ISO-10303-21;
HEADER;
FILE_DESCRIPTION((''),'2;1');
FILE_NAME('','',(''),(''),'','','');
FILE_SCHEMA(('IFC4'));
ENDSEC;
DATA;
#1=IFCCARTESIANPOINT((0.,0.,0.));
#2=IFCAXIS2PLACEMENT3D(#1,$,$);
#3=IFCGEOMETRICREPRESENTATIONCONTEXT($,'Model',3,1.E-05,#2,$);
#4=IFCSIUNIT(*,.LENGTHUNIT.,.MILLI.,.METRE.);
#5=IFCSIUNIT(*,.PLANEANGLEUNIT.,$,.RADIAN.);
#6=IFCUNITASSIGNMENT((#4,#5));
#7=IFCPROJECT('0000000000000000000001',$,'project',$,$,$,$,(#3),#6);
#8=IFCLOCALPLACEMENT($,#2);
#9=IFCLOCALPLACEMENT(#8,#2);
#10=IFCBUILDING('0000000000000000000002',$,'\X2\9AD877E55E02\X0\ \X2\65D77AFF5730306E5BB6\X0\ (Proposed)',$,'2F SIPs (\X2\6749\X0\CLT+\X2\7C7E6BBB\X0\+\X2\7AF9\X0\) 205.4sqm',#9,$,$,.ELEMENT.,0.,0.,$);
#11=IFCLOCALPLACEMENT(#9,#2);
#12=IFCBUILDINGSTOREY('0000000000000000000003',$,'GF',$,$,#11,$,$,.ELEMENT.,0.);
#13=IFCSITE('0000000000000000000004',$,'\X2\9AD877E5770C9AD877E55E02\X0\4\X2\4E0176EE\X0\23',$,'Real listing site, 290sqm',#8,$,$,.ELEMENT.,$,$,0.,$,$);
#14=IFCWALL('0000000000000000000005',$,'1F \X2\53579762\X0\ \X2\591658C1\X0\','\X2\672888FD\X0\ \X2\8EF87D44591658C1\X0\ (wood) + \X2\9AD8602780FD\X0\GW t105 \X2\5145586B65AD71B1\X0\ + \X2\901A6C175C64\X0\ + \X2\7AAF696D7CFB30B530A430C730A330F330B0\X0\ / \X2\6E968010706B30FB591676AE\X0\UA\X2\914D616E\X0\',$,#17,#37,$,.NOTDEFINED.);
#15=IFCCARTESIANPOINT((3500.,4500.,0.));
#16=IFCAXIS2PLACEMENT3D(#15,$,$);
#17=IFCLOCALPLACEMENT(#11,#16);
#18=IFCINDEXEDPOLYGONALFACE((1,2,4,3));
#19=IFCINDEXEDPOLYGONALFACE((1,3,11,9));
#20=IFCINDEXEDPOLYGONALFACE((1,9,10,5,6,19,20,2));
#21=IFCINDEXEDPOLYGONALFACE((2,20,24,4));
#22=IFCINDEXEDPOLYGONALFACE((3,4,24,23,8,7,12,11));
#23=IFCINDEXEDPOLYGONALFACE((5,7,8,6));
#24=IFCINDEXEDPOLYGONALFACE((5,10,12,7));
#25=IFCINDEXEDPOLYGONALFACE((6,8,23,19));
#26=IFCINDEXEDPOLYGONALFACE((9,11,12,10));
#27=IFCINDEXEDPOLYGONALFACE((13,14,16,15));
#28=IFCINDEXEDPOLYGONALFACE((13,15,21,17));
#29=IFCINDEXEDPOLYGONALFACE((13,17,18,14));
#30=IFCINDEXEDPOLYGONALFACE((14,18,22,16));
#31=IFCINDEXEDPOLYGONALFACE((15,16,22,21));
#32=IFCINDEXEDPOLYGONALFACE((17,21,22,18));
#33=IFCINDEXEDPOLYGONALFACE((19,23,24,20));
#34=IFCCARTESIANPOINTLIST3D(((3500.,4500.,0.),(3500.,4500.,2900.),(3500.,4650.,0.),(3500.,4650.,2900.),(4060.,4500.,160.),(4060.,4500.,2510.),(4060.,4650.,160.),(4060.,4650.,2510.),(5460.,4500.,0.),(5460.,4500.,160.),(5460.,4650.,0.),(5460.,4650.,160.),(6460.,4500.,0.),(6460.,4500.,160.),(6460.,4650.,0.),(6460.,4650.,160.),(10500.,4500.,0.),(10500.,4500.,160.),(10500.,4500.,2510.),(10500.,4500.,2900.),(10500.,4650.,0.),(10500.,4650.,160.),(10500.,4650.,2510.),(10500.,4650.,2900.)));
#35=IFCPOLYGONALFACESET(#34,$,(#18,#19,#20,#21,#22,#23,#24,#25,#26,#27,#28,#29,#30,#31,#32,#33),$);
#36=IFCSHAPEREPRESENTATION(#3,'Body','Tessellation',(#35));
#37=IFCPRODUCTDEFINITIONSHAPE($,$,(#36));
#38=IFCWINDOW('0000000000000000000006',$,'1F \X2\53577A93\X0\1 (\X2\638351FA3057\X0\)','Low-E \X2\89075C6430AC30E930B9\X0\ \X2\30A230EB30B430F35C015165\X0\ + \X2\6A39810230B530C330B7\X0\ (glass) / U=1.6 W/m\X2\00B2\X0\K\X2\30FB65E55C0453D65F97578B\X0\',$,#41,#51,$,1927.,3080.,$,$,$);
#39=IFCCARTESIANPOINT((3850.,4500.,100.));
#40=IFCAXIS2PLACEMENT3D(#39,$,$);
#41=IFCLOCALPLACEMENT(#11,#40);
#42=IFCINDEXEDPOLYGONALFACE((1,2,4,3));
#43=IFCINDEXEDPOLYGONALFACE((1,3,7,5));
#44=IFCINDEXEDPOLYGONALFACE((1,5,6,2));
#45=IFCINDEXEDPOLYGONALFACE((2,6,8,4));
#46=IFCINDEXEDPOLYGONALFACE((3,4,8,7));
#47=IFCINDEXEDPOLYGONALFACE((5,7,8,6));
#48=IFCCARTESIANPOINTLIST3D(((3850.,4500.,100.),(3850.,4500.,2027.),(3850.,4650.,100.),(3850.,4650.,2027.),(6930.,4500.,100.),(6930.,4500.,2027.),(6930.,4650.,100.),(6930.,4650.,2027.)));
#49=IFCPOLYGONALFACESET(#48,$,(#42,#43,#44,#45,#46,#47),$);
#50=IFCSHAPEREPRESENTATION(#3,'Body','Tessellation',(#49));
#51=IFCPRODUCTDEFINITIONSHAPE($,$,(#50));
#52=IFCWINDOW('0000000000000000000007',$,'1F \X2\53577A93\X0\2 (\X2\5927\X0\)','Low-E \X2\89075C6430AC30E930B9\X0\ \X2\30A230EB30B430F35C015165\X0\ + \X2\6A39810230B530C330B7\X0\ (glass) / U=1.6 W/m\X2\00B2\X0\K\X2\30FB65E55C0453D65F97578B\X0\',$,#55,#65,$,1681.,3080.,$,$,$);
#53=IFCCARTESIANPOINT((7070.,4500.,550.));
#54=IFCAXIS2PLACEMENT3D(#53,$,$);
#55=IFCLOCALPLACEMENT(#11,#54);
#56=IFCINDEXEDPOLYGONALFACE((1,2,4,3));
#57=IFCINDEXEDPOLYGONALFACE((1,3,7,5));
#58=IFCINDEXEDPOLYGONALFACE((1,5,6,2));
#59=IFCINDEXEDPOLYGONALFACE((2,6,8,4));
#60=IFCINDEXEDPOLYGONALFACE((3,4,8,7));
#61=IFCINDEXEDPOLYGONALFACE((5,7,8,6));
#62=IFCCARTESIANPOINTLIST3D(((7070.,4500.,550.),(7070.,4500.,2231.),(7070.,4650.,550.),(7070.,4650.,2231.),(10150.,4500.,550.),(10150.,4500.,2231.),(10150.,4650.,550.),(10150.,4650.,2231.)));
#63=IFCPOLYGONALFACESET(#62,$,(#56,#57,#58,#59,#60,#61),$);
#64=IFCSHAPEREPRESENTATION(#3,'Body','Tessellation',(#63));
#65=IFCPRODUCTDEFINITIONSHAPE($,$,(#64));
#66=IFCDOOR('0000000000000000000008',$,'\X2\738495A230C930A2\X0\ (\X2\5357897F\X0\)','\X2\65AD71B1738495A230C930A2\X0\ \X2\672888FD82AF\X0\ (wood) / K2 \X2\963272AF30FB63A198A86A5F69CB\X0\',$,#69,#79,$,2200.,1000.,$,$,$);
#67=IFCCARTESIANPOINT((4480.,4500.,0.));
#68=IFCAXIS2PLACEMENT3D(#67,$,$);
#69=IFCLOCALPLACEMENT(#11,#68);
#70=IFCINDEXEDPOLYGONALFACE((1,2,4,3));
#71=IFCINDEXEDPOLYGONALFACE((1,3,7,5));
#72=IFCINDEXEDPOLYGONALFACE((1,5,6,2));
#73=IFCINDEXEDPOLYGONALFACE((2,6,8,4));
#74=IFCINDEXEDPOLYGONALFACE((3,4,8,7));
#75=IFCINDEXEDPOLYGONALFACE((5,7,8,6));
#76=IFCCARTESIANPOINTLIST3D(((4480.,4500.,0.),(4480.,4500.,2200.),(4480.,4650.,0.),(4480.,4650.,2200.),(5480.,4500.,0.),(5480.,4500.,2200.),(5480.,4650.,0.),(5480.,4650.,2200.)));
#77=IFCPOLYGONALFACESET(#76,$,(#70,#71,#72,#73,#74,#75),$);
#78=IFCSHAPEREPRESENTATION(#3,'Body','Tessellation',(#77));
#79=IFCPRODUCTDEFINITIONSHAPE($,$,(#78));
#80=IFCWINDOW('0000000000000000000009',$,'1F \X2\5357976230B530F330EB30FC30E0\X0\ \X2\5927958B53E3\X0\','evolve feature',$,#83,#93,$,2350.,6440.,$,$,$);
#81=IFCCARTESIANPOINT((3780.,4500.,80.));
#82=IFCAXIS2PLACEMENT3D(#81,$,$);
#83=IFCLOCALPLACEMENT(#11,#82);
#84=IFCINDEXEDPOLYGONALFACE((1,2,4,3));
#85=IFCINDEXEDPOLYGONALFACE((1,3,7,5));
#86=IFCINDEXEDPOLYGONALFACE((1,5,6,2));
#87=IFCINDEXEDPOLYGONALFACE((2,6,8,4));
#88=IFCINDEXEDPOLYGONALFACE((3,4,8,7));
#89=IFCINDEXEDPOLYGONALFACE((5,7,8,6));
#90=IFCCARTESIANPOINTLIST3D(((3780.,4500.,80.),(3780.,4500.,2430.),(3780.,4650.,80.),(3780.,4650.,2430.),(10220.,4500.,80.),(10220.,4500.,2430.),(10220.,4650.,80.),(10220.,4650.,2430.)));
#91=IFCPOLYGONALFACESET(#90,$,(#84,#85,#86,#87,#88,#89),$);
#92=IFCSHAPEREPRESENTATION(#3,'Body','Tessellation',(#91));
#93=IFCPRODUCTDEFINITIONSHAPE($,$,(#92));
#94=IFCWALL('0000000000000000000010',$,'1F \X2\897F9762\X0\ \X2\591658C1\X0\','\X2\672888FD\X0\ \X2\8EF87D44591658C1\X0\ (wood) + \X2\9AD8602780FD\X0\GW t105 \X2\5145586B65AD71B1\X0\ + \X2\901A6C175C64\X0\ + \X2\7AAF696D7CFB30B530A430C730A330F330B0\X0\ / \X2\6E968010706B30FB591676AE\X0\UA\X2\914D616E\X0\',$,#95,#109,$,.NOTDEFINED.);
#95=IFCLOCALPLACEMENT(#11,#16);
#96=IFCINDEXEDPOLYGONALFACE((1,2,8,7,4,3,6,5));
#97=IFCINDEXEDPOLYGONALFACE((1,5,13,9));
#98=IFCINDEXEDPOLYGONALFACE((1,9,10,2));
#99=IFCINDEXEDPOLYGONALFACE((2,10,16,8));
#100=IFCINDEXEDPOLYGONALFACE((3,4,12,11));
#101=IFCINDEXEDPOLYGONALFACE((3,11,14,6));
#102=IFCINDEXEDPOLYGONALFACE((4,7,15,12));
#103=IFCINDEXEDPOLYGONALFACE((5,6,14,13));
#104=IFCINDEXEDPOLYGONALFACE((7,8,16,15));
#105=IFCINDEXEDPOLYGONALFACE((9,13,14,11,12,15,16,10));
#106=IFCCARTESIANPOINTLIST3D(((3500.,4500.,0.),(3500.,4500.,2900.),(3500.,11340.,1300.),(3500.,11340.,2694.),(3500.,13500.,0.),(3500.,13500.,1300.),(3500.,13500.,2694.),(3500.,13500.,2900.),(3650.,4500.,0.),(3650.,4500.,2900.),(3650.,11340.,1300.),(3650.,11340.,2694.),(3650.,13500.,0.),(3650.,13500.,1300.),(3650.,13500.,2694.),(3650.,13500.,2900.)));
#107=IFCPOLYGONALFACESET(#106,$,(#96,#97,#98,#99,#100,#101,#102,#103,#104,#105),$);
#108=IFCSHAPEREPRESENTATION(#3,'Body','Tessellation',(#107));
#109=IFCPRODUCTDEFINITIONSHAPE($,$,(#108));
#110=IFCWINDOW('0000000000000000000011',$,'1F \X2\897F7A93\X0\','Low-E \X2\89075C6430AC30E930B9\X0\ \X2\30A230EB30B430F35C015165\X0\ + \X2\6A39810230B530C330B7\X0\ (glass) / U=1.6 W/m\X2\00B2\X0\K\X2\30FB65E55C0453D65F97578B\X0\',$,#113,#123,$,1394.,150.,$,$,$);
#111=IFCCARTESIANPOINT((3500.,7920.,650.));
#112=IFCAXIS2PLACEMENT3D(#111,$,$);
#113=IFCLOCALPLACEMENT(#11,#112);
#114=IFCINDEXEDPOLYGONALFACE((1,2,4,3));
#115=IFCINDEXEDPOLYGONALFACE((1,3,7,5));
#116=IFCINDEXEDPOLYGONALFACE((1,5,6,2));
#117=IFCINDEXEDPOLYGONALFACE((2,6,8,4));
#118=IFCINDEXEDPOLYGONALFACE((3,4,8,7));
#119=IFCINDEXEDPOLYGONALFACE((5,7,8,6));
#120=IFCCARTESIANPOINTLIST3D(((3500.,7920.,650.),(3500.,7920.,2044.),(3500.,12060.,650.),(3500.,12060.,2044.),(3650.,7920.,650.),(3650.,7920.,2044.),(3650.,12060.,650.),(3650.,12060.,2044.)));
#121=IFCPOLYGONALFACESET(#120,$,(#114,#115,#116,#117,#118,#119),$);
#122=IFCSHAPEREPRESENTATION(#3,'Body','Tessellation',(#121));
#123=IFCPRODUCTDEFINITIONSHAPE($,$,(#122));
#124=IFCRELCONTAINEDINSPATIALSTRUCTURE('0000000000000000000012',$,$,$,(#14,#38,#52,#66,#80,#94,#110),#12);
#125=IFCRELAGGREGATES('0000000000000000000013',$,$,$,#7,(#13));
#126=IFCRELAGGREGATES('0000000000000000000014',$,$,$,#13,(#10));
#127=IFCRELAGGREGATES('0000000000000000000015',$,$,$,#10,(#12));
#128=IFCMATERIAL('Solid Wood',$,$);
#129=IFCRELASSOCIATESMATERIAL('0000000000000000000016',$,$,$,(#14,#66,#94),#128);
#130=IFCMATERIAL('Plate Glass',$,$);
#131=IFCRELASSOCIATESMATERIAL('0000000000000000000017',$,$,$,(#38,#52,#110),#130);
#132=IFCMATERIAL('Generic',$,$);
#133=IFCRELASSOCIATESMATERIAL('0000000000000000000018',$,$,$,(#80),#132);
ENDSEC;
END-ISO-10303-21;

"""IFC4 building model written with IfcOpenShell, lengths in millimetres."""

from ifc_helpers import new_model, si_unit, frame, frame_2d, origin, place, context, project, spatial, rectangle, extrude, material, element, fill, save


model = new_model("IFC4")

# Units and contexts
model_context = context("Model", 3, precision=1e-05, world=origin())
ifc_project = project(units=[si_unit("LENGTHUNIT", "METRE", prefix="MILLI"), si_unit("PLANEANGLEUNIT", "RADIAN")], contexts=[model_context])

# Site, building, storey
site_placement = place(None, origin())
site = spatial("IfcSite", under=ifc_project, at=site_placement, Name="高知県高知市4丁目23", ObjectType="Real listing site, 290sqm", CompositionType="ELEMENT", RefElevation=0.0)
building_placement = place(site_placement, origin())
building = spatial("IfcBuilding", under=site, at=building_placement, Name="高知市 旗竿地の家 (Proposed)", ObjectType="2F SIPs (杉CLT+籾殻+竹) 205.4sqm", CompositionType="ELEMENT", ElevationOfRefHeight=0.0, ElevationOfTerrain=0.0)
storey_placement = place(building_placement, origin())
storey = spatial("IfcBuildingStorey", under=building, at=storey_placement, Name="GF", CompositionType="ELEMENT", Elevation=0.0)

# Shared definitions
ifc_material_1 = material(Name="Solid Wood")

# Wall, openings, windows, door
wall_1_placement = place(storey_placement, frame((3500.0, 4500.0, 0.0)))
wall_1 = element("IfcWall", 1, at=wall_1_placement, inside=storey, material=ifc_material_1, Name="1F 南面 外壁", Description="木製 軸組外壁 (wood) + 高性能GW t105 充填断熱 + 通気層 + 窯業系サイディング / 準耐火・外皮UA配慮", PredefinedType="NOTDEFINED", context=model_context, shape_type="SweptSolid", body=[
    extrude(rectangle(XDim=7000.0, YDim=150.0, at=frame_2d((3500.0, 75.0))), frame((3500.0, 4500.0, 0.0)), (0.0, 0.0, 1.0), 2900.0),
])
opening_1_placement = place(storey_placement, frame((3850.0, 4500.0, 100.0)))
opening_1 = element("IfcOpeningElement", 2, at=opening_1_placement, cuts=wall_1, PredefinedType="NOTDEFINED", context=model_context, shape_type="SweptSolid", body=[
    extrude(rectangle(XDim=3080.0, YDim=150.0, at=frame_2d((1540.0, 75.0))), frame((3850.0, 4500.0, 100.0)), (0.0, 0.0, 1.0), 1927.0),
])
opening_2_placement = place(storey_placement, frame((7070.0, 4500.0, 550.0)))
opening_2 = element("IfcOpeningElement", 3, at=opening_2_placement, cuts=wall_1, PredefinedType="NOTDEFINED", context=model_context, shape_type="SweptSolid", body=[
    extrude(rectangle(XDim=3080.0, YDim=150.0, at=frame_2d((1540.0, 75.0))), frame((7070.0, 4500.0, 550.0)), (0.0, 0.0, 1.0), 1681.0),
])
opening_3_placement = place(storey_placement, frame((4480.0, 4500.0, 0.0)))
opening_3 = element("IfcOpeningElement", 4, at=opening_3_placement, cuts=wall_1, PredefinedType="NOTDEFINED", context=model_context, shape_type="SweptSolid", body=[
    extrude(rectangle(XDim=1000.0, YDim=150.0, at=frame_2d((500.0, 75.0))), frame((4480.0, 4500.0, 0.0)), (0.0, 0.0, 1.0), 2200.0),
])
opening_4_placement = place(storey_placement, frame((3780.0, 4500.0, 80.0)))
opening_4 = element("IfcOpeningElement", 5, at=opening_4_placement, cuts=wall_1, PredefinedType="NOTDEFINED", context=model_context, shape_type="SweptSolid", body=[
    extrude(rectangle(XDim=6440.0, YDim=150.0, at=frame_2d((3220.0, 75.0))), frame((3780.0, 4500.0, 80.0)), (0.0, 0.0, 1.0), 2350.0),
])
ifc_material_2 = material(Name="Plate Glass")
window_1_placement = place(storey_placement, frame((3850.0, 4500.0, 100.0)))
window_1 = element("IfcWindow", 6, at=window_1_placement, inside=storey, material=ifc_material_2, Name="1F 南窓1 (掃出し)", Description="Low-E 複層ガラス アルゴン封入 + 樹脂サッシ (glass) / U=1.6 W/m²K・日射取得型", OverallHeight=1927.0, OverallWidth=3080.0, context=model_context, shape_type="SweptSolid", body=[
    extrude(rectangle(XDim=3080.0, YDim=150.0, at=frame_2d((1540.0, 75.0))), frame((3850.0, 4500.0, 100.0)), (0.0, 0.0, 1.0), 1927.0),
])
fill(opening_1, window_1)
window_2_placement = place(storey_placement, frame((7070.0, 4500.0, 550.0)))
window_2 = element("IfcWindow", 7, at=window_2_placement, inside=storey, material=ifc_material_2, Name="1F 南窓2 (大)", Description="Low-E 複層ガラス アルゴン封入 + 樹脂サッシ (glass) / U=1.6 W/m²K・日射取得型", OverallHeight=1681.0, OverallWidth=3080.0, context=model_context, shape_type="SweptSolid", body=[
    extrude(rectangle(XDim=3080.0, YDim=150.0, at=frame_2d((1540.0, 75.0))), frame((7070.0, 4500.0, 550.0)), (0.0, 0.0, 1.0), 1681.0),
])
fill(opening_2, window_2)
door_placement = place(storey_placement, frame((4480.0, 4500.0, 0.0)))
door = element("IfcDoor", 8, at=door_placement, inside=storey, material=ifc_material_1, Name="玄関ドア (南西)", Description="断熱玄関ドア 木製芯 (wood) / K2 防犯・採風機構", OverallHeight=2200.0, OverallWidth=1000.0, context=model_context, shape_type="SweptSolid", body=[
    extrude(rectangle(XDim=1000.0, YDim=150.0, at=frame_2d((500.0, 75.0))), frame((4480.0, 4500.0, 0.0)), (0.0, 0.0, 1.0), 2200.0),
])
fill(opening_3, door)
ifc_material_3 = material(Name="Generic")
window_3_placement = place(storey_placement, frame((3780.0, 4500.0, 80.0)))
window_3 = element("IfcWindow", 9, at=window_3_placement, inside=storey, material=ifc_material_3, Name="1F 南面サンルーム 大開口", Description="evolve feature", OverallHeight=2350.0, OverallWidth=6440.0, context=model_context, shape_type="SweptSolid", body=[
    extrude(rectangle(XDim=6440.0, YDim=150.0, at=frame_2d((3220.0, 75.0))), frame((3780.0, 4500.0, 80.0)), (0.0, 0.0, 1.0), 2350.0),
])
fill(opening_4, window_3)

# Wall, opening, window
wall_2_placement = place(storey_placement, frame((3500.0, 4500.0, 0.0)))
wall_2 = element("IfcWall", 10, at=wall_2_placement, inside=storey, material=ifc_material_1, Name="1F 西面 外壁", Description="木製 軸組外壁 (wood) + 高性能GW t105 充填断熱 + 通気層 + 窯業系サイディング / 準耐火・外皮UA配慮", PredefinedType="NOTDEFINED", context=model_context, shape_type="SweptSolid", body=[
    extrude(rectangle(XDim=150.0, YDim=9000.0, at=frame_2d((75.0, 4500.0))), frame((3500.0, 4500.0, 0.0)), (0.0, 0.0, 1.0), 2900.0),
])
opening_5_placement = place(storey_placement, frame((3500.0, 7920.0, 650.0)))
opening_5 = element("IfcOpeningElement", 11, at=opening_5_placement, cuts=wall_2, PredefinedType="NOTDEFINED", context=model_context, shape_type="SweptSolid", body=[
    extrude(rectangle(XDim=150.0, YDim=4140.0, at=frame_2d((75.0, 2070.0))), frame((3500.0, 7920.0, 650.0)), (0.0, 0.0, 1.0), 1394.0),
])
window_4_placement = place(storey_placement, frame((3500.0, 7920.0, 650.0)))
window_4 = element("IfcWindow", 12, at=window_4_placement, inside=storey, material=ifc_material_2, Name="1F 西窓", Description="Low-E 複層ガラス アルゴン封入 + 樹脂サッシ (glass) / U=1.6 W/m²K・日射取得型", OverallHeight=1394.0, OverallWidth=150.0, context=model_context, shape_type="SweptSolid", body=[
    extrude(rectangle(XDim=150.0, YDim=4140.0, at=frame_2d((75.0, 2070.0))), frame((3500.0, 7920.0, 650.0)), (0.0, 0.0, 1.0), 1394.0),
])
fill(opening_5, window_4)

save(model, "model.ifc")
